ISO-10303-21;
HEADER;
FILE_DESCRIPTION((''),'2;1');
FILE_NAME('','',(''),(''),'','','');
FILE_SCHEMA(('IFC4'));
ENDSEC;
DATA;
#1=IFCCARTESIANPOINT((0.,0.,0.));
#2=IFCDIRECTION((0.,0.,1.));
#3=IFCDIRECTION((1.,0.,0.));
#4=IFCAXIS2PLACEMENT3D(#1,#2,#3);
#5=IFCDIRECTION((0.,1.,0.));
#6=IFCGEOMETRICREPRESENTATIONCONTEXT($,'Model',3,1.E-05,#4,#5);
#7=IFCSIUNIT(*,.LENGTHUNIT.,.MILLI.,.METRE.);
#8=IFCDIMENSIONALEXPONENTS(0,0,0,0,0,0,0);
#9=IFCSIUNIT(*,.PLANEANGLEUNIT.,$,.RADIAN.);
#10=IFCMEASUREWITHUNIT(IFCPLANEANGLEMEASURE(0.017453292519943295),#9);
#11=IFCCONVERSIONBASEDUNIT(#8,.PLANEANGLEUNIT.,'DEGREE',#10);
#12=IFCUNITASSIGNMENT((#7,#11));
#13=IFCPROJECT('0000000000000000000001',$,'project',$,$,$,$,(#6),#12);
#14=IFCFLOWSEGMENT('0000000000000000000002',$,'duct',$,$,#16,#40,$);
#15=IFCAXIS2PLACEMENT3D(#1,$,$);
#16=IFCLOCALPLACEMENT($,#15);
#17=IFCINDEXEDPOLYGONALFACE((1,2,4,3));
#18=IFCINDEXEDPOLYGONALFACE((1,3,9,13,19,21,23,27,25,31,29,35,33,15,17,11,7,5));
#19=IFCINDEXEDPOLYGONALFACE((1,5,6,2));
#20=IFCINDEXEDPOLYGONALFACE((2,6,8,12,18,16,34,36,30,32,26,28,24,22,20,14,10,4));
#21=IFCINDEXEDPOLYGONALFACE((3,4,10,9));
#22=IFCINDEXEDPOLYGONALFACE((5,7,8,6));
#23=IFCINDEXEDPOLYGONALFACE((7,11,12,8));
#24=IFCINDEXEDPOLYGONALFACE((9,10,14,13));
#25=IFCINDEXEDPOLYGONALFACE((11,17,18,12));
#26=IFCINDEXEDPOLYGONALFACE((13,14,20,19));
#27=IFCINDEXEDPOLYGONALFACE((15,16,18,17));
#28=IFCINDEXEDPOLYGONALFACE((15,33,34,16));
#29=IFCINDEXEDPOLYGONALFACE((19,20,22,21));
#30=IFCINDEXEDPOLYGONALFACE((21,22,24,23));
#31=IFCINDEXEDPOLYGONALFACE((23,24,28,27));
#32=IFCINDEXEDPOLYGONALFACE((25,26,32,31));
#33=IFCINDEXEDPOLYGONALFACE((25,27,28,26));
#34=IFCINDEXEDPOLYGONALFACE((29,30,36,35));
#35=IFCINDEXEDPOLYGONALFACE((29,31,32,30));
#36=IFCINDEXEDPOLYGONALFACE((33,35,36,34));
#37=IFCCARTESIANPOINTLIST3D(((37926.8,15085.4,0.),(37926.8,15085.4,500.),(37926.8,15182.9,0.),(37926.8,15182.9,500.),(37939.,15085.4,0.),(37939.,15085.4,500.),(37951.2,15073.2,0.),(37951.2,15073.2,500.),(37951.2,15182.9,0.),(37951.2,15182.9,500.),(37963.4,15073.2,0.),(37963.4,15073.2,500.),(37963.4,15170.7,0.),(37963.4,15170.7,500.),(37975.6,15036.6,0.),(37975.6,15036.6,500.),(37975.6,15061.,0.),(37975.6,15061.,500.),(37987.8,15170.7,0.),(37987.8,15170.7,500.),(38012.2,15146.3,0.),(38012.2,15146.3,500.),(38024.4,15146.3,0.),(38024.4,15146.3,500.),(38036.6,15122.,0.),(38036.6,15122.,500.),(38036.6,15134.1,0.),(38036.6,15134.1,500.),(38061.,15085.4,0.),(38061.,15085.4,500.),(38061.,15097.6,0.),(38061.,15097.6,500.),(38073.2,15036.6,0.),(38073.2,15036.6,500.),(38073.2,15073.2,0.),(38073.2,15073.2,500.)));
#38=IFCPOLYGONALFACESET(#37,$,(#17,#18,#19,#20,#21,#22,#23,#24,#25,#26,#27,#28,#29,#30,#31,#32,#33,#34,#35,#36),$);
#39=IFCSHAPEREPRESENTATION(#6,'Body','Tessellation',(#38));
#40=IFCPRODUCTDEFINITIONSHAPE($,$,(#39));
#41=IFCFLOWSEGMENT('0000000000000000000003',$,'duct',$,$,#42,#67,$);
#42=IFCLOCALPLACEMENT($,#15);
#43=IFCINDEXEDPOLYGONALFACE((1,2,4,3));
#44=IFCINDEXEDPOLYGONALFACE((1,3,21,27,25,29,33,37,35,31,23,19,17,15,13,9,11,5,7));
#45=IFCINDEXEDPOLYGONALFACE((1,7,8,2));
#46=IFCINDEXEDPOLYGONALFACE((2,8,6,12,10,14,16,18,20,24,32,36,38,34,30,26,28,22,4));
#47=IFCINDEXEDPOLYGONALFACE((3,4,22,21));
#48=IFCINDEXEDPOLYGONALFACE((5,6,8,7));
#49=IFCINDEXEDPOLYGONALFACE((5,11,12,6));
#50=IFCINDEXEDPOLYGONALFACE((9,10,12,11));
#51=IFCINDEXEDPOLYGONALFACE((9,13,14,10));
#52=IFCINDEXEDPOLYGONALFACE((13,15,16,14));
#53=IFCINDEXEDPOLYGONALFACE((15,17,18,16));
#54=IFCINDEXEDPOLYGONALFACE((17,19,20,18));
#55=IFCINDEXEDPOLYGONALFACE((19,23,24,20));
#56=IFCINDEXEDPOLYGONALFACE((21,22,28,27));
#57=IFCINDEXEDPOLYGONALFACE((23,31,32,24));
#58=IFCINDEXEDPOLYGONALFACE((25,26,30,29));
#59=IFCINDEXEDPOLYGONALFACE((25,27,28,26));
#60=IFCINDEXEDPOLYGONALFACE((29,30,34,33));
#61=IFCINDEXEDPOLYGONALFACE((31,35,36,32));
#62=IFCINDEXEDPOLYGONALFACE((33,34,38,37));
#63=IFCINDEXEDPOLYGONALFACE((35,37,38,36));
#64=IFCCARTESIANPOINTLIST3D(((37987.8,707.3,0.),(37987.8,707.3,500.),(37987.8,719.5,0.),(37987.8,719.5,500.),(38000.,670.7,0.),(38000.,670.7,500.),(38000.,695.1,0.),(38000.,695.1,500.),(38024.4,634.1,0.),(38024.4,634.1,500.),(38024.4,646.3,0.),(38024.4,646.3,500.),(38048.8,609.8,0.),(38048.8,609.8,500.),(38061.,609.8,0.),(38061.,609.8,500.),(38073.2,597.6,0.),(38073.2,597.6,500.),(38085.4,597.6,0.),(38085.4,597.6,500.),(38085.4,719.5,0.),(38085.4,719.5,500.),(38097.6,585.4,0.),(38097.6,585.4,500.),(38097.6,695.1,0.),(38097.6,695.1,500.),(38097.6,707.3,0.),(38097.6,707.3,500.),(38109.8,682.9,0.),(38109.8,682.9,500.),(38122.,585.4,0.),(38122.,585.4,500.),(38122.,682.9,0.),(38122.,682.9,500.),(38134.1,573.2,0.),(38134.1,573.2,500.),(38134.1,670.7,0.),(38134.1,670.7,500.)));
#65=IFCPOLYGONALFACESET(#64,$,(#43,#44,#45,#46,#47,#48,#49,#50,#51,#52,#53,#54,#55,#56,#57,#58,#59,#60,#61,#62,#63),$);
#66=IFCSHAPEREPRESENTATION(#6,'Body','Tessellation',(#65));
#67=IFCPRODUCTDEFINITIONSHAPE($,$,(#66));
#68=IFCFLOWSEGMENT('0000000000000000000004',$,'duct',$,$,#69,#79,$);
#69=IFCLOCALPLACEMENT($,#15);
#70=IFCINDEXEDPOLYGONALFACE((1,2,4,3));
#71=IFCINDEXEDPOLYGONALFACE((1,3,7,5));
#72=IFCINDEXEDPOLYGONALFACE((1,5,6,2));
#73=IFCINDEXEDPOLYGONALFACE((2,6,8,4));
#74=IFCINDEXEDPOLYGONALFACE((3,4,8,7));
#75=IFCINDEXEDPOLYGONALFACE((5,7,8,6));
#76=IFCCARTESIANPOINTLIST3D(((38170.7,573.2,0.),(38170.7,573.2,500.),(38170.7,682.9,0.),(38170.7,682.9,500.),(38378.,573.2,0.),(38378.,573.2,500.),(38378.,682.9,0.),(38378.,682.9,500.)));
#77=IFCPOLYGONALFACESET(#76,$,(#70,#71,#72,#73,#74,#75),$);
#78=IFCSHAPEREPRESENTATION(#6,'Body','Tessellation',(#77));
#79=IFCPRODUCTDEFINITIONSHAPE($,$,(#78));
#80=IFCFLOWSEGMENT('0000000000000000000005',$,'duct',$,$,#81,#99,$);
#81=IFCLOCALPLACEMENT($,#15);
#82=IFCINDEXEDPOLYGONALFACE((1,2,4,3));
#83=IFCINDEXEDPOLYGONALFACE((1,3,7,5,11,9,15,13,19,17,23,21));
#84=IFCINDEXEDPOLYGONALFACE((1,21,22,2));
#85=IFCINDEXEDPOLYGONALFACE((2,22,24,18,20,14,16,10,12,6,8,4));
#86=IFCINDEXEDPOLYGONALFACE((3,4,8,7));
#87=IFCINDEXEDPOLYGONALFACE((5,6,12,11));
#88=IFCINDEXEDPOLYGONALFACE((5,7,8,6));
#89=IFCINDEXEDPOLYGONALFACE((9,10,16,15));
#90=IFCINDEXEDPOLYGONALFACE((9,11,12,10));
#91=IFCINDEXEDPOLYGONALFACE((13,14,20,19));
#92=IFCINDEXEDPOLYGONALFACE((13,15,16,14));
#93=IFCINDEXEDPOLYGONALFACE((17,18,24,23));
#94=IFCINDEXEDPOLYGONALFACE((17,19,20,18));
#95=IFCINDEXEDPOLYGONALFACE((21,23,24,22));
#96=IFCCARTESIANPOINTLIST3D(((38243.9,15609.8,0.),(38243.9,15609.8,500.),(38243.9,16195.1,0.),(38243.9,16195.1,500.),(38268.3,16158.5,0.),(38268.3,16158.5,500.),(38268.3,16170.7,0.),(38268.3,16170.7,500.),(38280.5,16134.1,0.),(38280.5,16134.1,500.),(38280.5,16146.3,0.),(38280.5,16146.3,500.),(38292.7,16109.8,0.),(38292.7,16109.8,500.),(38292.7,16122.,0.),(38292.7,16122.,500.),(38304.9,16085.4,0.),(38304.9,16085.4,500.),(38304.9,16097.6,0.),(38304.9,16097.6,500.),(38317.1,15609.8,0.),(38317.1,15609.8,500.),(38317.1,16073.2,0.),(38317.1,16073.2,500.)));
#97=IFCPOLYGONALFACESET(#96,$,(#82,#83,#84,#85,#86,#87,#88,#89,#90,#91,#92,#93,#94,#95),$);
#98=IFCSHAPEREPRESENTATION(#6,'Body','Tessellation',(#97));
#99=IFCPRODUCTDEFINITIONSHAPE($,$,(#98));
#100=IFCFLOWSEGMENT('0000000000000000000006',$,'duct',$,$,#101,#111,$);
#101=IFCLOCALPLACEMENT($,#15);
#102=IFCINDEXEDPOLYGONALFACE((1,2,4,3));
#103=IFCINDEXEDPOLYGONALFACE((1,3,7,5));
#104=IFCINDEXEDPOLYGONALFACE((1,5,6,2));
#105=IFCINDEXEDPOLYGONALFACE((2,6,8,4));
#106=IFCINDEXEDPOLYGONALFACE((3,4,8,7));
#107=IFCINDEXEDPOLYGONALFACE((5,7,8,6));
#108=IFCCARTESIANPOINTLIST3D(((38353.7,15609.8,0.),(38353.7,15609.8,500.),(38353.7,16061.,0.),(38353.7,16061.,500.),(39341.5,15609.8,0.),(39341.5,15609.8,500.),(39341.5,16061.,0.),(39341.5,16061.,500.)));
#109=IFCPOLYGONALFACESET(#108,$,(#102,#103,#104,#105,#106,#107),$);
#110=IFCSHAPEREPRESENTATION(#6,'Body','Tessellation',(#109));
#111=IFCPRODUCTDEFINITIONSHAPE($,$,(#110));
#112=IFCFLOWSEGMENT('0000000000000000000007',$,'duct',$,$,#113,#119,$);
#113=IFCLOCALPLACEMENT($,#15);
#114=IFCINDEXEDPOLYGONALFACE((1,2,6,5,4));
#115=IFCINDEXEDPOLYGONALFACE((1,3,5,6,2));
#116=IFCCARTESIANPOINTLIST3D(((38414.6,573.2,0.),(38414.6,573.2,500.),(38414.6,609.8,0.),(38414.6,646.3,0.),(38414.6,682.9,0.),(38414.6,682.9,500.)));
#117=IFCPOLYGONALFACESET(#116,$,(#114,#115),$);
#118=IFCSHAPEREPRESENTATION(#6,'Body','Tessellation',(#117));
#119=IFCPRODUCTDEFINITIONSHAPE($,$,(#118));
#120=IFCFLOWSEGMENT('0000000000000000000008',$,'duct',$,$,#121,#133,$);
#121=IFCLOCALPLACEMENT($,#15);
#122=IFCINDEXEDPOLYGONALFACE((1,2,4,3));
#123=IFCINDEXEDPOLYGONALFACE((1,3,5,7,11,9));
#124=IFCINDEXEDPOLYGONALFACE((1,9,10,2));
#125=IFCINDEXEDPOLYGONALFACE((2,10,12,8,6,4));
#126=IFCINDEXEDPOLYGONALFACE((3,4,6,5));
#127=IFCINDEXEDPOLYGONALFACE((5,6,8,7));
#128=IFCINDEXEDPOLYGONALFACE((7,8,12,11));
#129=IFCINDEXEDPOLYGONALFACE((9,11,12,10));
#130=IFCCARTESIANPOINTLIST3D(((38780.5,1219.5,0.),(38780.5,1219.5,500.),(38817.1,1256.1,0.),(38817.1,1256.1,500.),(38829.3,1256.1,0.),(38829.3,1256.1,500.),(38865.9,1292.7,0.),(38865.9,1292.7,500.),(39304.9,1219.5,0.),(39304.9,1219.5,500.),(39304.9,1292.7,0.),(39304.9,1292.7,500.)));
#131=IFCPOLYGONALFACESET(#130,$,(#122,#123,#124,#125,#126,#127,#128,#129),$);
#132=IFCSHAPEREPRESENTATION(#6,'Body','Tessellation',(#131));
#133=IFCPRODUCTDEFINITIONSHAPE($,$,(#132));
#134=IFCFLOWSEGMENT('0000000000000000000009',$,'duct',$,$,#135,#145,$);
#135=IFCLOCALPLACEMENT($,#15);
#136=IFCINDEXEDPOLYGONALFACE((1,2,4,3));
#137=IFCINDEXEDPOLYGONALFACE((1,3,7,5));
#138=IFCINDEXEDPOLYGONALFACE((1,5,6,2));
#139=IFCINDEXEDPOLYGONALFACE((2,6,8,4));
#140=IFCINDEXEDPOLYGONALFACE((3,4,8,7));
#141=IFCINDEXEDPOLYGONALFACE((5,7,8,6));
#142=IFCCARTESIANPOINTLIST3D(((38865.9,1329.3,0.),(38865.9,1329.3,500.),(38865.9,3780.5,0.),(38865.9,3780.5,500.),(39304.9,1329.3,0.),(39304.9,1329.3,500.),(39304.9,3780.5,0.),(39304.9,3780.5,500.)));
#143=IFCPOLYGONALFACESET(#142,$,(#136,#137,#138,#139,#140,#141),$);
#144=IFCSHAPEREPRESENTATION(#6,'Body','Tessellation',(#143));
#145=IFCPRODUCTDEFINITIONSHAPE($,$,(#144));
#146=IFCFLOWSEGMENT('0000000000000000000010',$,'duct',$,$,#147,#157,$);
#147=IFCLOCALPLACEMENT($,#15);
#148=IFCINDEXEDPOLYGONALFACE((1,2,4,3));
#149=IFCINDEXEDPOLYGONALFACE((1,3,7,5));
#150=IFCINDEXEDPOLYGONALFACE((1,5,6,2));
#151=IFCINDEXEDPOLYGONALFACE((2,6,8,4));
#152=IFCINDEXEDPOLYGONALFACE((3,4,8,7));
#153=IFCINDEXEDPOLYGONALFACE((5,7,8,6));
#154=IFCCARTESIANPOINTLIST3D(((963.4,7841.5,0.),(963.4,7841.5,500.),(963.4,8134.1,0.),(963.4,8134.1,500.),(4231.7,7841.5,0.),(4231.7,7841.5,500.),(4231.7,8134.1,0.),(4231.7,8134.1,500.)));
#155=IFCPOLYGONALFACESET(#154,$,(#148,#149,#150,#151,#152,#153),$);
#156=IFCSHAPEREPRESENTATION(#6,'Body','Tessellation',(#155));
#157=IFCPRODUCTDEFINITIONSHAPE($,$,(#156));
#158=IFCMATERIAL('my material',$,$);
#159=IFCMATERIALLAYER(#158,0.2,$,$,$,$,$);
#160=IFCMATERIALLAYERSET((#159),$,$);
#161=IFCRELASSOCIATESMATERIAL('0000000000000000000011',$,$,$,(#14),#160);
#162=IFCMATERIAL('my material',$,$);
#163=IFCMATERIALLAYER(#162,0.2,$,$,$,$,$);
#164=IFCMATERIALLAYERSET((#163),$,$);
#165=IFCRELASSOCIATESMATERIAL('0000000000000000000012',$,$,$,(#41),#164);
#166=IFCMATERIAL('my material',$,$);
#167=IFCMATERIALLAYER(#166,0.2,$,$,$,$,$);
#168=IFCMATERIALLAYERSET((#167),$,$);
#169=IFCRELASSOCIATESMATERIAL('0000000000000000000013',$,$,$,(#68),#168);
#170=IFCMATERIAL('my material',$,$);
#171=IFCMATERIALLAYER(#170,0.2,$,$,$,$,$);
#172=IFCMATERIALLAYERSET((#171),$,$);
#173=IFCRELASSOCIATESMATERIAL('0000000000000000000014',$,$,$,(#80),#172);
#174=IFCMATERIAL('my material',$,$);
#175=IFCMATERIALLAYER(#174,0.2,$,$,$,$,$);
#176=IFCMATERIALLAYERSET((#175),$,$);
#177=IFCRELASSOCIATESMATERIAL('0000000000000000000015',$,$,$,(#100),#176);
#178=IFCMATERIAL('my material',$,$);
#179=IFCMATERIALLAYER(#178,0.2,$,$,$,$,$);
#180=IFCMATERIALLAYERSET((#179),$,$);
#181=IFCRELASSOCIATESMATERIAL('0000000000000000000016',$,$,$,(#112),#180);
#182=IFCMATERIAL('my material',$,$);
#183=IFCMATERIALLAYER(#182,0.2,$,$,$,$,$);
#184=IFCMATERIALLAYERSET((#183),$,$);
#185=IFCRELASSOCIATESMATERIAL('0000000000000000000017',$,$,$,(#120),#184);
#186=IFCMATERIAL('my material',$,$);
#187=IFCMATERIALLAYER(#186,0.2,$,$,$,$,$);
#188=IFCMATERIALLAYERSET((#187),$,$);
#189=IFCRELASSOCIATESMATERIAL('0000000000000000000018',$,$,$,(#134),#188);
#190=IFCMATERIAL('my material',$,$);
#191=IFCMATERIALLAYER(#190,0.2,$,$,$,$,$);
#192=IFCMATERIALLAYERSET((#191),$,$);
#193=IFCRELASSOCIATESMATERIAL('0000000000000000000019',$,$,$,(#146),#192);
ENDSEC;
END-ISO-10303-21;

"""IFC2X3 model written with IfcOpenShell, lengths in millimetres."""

from ifc_helpers import new_model, entity, si_unit, converted_unit, direction, origin_with_axes, place, context, project, polyline, outline, extrude, material, layer, layer_set, layer_usage, element, save


model = new_model("IFC2X3")

# Units and contexts
model_context = context("Model", 3, precision=1e-05, world=origin_with_axes(), true_north=direction((0.0, 1.0, 0.0)))
ifc_project = project(units=[si_unit("LENGTHUNIT", "METRE", prefix="MILLI"), converted_unit("PLANEANGLEUNIT", "DEGREE", entity("IfcPlaneAngleMeasure", 0.017453292519943295), si_unit("PLANEANGLEUNIT", "RADIAN"), dimensions=[0, 0, 0, 0, 0, 0, 0])], contexts=[model_context])

# Flow segments
ifc_material_1 = material(Name="my material")
ifc_layer_1 = layer(ifc_material_1, 0.2)
ifc_layer_set_1 = layer_set([ifc_layer_1])
ifc_layer_usage_1 = layer_usage(ifc_layer_set_1, "AXIS2", "POSITIVE", -0.1)
flow_segment_1_placement = place(None, origin_with_axes())
element("IfcFlowSegment", 1, at=flow_segment_1_placement, material=ifc_layer_usage_1, Name="duct", context=model_context, shape_type="SweptSolid", body=[
    extrude(outline(polyline([(37926.8, 15085.4), (37939.0, 15085.4), (37951.2, 15073.2), (37963.4, 15073.2), (37975.6, 15061.0), (37975.6, 15036.6), (38073.2, 15036.6), (38073.2, 15073.2), (38061.0, 15085.4), (38061.0, 15097.6), (38036.6, 15122.0), (38036.6, 15134.1), (38024.4, 15146.3), (38012.2, 15146.3), (37987.8, 15170.7), (37963.4, 15170.7), (37951.2, 15182.9), (37926.8, 15182.9), (37926.8, 15085.4)])), origin_with_axes(), (0.0, 0.0, 1.0), 500.0),
])
ifc_material_2 = material(Name="my material")
ifc_layer_2 = layer(ifc_material_2, 0.2)
ifc_layer_set_2 = layer_set([ifc_layer_2])
ifc_layer_usage_2 = layer_usage(ifc_layer_set_2, "AXIS2", "POSITIVE", -0.1)
flow_segment_2_placement = place(None, origin_with_axes())
element("IfcFlowSegment", 2, at=flow_segment_2_placement, material=ifc_layer_usage_2, Name="duct", context=model_context, shape_type="SweptSolid", body=[
    extrude(outline(polyline([(37987.8, 707.3), (38000.0, 695.1), (38000.0, 670.7), (38024.4, 646.3), (38024.4, 634.1), (38048.8, 609.8), (38061.0, 609.8), (38073.2, 597.6), (38085.4, 597.6), (38097.6, 585.4), (38122.0, 585.4), (38134.1, 573.2), (38134.1, 670.7), (38122.0, 682.9), (38109.8, 682.9), (38097.6, 695.1), (38097.6, 707.3), (38085.4, 719.5), (37987.8, 719.5), (37987.8, 707.3)])), origin_with_axes(), (0.0, 0.0, 1.0), 500.0),
])
ifc_material_3 = material(Name="my material")
ifc_layer_3 = layer(ifc_material_3, 0.2)
ifc_layer_set_3 = layer_set([ifc_layer_3])
ifc_layer_usage_3 = layer_usage(ifc_layer_set_3, "AXIS2", "POSITIVE", -0.1)
flow_segment_3_placement = place(None, origin_with_axes())
element("IfcFlowSegment", 3, at=flow_segment_3_placement, material=ifc_layer_usage_3, Name="duct", context=model_context, shape_type="SweptSolid", body=[
    extrude(outline(polyline([(38170.7, 573.2), (38378.0, 573.2), (38378.0, 682.9), (38170.7, 682.9), (38170.7, 573.2)])), origin_with_axes(), (0.0, 0.0, 1.0), 500.0),
])
ifc_material_4 = material(Name="my material")
ifc_layer_4 = layer(ifc_material_4, 0.2)
ifc_layer_set_4 = layer_set([ifc_layer_4])
ifc_layer_usage_4 = layer_usage(ifc_layer_set_4, "AXIS2", "POSITIVE", -0.1)
flow_segment_4_placement = place(None, origin_with_axes())
element("IfcFlowSegment", 4, at=flow_segment_4_placement, material=ifc_layer_usage_4, Name="duct", context=model_context, shape_type="SweptSolid", body=[
    extrude(outline(polyline([(38243.9, 15609.8), (38317.1, 15609.8), (38317.1, 16073.2), (38304.9, 16085.4), (38304.9, 16097.6), (38292.7, 16109.8), (38292.7, 16122.0), (38280.5, 16134.1), (38280.5, 16146.3), (38268.3, 16158.5), (38268.3, 16170.7), (38243.9, 16195.1), (38243.9, 16207.3), (38243.9, 15609.8)])), origin_with_axes(), (0.0, 0.0, 1.0), 500.0),
])
ifc_material_5 = material(Name="my material")
ifc_layer_5 = layer(ifc_material_5, 0.2)
ifc_layer_set_5 = layer_set([ifc_layer_5])
ifc_layer_usage_5 = layer_usage(ifc_layer_set_5, "AXIS2", "POSITIVE", -0.1)
flow_segment_5_placement = place(None, origin_with_axes())
element("IfcFlowSegment", 5, at=flow_segment_5_placement, material=ifc_layer_usage_5, Name="duct", context=model_context, shape_type="SweptSolid", body=[
    extrude(outline(polyline([(38353.7, 15609.8), (39341.5, 15609.8), (39341.5, 16061.0), (38353.7, 16061.0), (38353.7, 15609.8)])), origin_with_axes(), (0.0, 0.0, 1.0), 500.0),
])
ifc_material_6 = material(Name="my material")
ifc_layer_6 = layer(ifc_material_6, 0.2)
ifc_layer_set_6 = layer_set([ifc_layer_6])
ifc_layer_usage_6 = layer_usage(ifc_layer_set_6, "AXIS2", "POSITIVE", -0.1)
flow_segment_6_placement = place(None, origin_with_axes())
element("IfcFlowSegment", 6, at=flow_segment_6_placement, material=ifc_layer_usage_6, Name="duct", context=model_context, shape_type="SweptSolid", body=[
    extrude(outline(polyline([(38414.6, 573.2), (38414.6, 682.9), (38414.6, 573.2)])), origin_with_axes(), (0.0, 0.0, 1.0), 500.0),
])
ifc_material_7 = material(Name="my material")
ifc_layer_7 = layer(ifc_material_7, 0.2)
ifc_layer_set_7 = layer_set([ifc_layer_7])
ifc_layer_usage_7 = layer_usage(ifc_layer_set_7, "AXIS2", "POSITIVE", -0.1)
flow_segment_7_placement = place(None, origin_with_axes())
element("IfcFlowSegment", 7, at=flow_segment_7_placement, material=ifc_layer_usage_7, Name="duct", context=model_context, shape_type="SweptSolid", body=[
    extrude(outline(polyline([(38780.5, 1219.5), (39304.9, 1219.5), (39304.9, 1292.7), (38865.9, 1292.7), (38829.3, 1256.1), (38817.1, 1256.1), (38780.5, 1219.5)])), origin_with_axes(), (0.0, 0.0, 1.0), 500.0),
])
ifc_material_8 = material(Name="my material")
ifc_layer_8 = layer(ifc_material_8, 0.2)
ifc_layer_set_8 = layer_set([ifc_layer_8])
ifc_layer_usage_8 = layer_usage(ifc_layer_set_8, "AXIS2", "POSITIVE", -0.1)
flow_segment_8_placement = place(None, origin_with_axes())
element("IfcFlowSegment", 8, at=flow_segment_8_placement, material=ifc_layer_usage_8, Name="duct", context=model_context, shape_type="SweptSolid", body=[
    extrude(outline(polyline([(38865.9, 1329.3), (39304.9, 1329.3), (39304.9, 3780.5), (38865.9, 3780.5), (38865.9, 1329.3)])), origin_with_axes(), (0.0, 0.0, 1.0), 500.0),
])
ifc_material_9 = material(Name="my material")
ifc_layer_9 = layer(ifc_material_9, 0.2)
ifc_layer_set_9 = layer_set([ifc_layer_9])
ifc_layer_usage_9 = layer_usage(ifc_layer_set_9, "AXIS2", "POSITIVE", -0.1)
flow_segment_9_placement = place(None, origin_with_axes())
element("IfcFlowSegment", 9, at=flow_segment_9_placement, material=ifc_layer_usage_9, Name="duct", context=model_context, shape_type="SweptSolid", body=[
    extrude(outline(polyline([(963.4, 7841.5), (4231.7, 7841.5), (4231.7, 8134.1), (963.4, 8134.1), (963.4, 7841.5)])), origin_with_axes(), (0.0, 0.0, 1.0), 500.0),
])

save(model, "model.ifc")
